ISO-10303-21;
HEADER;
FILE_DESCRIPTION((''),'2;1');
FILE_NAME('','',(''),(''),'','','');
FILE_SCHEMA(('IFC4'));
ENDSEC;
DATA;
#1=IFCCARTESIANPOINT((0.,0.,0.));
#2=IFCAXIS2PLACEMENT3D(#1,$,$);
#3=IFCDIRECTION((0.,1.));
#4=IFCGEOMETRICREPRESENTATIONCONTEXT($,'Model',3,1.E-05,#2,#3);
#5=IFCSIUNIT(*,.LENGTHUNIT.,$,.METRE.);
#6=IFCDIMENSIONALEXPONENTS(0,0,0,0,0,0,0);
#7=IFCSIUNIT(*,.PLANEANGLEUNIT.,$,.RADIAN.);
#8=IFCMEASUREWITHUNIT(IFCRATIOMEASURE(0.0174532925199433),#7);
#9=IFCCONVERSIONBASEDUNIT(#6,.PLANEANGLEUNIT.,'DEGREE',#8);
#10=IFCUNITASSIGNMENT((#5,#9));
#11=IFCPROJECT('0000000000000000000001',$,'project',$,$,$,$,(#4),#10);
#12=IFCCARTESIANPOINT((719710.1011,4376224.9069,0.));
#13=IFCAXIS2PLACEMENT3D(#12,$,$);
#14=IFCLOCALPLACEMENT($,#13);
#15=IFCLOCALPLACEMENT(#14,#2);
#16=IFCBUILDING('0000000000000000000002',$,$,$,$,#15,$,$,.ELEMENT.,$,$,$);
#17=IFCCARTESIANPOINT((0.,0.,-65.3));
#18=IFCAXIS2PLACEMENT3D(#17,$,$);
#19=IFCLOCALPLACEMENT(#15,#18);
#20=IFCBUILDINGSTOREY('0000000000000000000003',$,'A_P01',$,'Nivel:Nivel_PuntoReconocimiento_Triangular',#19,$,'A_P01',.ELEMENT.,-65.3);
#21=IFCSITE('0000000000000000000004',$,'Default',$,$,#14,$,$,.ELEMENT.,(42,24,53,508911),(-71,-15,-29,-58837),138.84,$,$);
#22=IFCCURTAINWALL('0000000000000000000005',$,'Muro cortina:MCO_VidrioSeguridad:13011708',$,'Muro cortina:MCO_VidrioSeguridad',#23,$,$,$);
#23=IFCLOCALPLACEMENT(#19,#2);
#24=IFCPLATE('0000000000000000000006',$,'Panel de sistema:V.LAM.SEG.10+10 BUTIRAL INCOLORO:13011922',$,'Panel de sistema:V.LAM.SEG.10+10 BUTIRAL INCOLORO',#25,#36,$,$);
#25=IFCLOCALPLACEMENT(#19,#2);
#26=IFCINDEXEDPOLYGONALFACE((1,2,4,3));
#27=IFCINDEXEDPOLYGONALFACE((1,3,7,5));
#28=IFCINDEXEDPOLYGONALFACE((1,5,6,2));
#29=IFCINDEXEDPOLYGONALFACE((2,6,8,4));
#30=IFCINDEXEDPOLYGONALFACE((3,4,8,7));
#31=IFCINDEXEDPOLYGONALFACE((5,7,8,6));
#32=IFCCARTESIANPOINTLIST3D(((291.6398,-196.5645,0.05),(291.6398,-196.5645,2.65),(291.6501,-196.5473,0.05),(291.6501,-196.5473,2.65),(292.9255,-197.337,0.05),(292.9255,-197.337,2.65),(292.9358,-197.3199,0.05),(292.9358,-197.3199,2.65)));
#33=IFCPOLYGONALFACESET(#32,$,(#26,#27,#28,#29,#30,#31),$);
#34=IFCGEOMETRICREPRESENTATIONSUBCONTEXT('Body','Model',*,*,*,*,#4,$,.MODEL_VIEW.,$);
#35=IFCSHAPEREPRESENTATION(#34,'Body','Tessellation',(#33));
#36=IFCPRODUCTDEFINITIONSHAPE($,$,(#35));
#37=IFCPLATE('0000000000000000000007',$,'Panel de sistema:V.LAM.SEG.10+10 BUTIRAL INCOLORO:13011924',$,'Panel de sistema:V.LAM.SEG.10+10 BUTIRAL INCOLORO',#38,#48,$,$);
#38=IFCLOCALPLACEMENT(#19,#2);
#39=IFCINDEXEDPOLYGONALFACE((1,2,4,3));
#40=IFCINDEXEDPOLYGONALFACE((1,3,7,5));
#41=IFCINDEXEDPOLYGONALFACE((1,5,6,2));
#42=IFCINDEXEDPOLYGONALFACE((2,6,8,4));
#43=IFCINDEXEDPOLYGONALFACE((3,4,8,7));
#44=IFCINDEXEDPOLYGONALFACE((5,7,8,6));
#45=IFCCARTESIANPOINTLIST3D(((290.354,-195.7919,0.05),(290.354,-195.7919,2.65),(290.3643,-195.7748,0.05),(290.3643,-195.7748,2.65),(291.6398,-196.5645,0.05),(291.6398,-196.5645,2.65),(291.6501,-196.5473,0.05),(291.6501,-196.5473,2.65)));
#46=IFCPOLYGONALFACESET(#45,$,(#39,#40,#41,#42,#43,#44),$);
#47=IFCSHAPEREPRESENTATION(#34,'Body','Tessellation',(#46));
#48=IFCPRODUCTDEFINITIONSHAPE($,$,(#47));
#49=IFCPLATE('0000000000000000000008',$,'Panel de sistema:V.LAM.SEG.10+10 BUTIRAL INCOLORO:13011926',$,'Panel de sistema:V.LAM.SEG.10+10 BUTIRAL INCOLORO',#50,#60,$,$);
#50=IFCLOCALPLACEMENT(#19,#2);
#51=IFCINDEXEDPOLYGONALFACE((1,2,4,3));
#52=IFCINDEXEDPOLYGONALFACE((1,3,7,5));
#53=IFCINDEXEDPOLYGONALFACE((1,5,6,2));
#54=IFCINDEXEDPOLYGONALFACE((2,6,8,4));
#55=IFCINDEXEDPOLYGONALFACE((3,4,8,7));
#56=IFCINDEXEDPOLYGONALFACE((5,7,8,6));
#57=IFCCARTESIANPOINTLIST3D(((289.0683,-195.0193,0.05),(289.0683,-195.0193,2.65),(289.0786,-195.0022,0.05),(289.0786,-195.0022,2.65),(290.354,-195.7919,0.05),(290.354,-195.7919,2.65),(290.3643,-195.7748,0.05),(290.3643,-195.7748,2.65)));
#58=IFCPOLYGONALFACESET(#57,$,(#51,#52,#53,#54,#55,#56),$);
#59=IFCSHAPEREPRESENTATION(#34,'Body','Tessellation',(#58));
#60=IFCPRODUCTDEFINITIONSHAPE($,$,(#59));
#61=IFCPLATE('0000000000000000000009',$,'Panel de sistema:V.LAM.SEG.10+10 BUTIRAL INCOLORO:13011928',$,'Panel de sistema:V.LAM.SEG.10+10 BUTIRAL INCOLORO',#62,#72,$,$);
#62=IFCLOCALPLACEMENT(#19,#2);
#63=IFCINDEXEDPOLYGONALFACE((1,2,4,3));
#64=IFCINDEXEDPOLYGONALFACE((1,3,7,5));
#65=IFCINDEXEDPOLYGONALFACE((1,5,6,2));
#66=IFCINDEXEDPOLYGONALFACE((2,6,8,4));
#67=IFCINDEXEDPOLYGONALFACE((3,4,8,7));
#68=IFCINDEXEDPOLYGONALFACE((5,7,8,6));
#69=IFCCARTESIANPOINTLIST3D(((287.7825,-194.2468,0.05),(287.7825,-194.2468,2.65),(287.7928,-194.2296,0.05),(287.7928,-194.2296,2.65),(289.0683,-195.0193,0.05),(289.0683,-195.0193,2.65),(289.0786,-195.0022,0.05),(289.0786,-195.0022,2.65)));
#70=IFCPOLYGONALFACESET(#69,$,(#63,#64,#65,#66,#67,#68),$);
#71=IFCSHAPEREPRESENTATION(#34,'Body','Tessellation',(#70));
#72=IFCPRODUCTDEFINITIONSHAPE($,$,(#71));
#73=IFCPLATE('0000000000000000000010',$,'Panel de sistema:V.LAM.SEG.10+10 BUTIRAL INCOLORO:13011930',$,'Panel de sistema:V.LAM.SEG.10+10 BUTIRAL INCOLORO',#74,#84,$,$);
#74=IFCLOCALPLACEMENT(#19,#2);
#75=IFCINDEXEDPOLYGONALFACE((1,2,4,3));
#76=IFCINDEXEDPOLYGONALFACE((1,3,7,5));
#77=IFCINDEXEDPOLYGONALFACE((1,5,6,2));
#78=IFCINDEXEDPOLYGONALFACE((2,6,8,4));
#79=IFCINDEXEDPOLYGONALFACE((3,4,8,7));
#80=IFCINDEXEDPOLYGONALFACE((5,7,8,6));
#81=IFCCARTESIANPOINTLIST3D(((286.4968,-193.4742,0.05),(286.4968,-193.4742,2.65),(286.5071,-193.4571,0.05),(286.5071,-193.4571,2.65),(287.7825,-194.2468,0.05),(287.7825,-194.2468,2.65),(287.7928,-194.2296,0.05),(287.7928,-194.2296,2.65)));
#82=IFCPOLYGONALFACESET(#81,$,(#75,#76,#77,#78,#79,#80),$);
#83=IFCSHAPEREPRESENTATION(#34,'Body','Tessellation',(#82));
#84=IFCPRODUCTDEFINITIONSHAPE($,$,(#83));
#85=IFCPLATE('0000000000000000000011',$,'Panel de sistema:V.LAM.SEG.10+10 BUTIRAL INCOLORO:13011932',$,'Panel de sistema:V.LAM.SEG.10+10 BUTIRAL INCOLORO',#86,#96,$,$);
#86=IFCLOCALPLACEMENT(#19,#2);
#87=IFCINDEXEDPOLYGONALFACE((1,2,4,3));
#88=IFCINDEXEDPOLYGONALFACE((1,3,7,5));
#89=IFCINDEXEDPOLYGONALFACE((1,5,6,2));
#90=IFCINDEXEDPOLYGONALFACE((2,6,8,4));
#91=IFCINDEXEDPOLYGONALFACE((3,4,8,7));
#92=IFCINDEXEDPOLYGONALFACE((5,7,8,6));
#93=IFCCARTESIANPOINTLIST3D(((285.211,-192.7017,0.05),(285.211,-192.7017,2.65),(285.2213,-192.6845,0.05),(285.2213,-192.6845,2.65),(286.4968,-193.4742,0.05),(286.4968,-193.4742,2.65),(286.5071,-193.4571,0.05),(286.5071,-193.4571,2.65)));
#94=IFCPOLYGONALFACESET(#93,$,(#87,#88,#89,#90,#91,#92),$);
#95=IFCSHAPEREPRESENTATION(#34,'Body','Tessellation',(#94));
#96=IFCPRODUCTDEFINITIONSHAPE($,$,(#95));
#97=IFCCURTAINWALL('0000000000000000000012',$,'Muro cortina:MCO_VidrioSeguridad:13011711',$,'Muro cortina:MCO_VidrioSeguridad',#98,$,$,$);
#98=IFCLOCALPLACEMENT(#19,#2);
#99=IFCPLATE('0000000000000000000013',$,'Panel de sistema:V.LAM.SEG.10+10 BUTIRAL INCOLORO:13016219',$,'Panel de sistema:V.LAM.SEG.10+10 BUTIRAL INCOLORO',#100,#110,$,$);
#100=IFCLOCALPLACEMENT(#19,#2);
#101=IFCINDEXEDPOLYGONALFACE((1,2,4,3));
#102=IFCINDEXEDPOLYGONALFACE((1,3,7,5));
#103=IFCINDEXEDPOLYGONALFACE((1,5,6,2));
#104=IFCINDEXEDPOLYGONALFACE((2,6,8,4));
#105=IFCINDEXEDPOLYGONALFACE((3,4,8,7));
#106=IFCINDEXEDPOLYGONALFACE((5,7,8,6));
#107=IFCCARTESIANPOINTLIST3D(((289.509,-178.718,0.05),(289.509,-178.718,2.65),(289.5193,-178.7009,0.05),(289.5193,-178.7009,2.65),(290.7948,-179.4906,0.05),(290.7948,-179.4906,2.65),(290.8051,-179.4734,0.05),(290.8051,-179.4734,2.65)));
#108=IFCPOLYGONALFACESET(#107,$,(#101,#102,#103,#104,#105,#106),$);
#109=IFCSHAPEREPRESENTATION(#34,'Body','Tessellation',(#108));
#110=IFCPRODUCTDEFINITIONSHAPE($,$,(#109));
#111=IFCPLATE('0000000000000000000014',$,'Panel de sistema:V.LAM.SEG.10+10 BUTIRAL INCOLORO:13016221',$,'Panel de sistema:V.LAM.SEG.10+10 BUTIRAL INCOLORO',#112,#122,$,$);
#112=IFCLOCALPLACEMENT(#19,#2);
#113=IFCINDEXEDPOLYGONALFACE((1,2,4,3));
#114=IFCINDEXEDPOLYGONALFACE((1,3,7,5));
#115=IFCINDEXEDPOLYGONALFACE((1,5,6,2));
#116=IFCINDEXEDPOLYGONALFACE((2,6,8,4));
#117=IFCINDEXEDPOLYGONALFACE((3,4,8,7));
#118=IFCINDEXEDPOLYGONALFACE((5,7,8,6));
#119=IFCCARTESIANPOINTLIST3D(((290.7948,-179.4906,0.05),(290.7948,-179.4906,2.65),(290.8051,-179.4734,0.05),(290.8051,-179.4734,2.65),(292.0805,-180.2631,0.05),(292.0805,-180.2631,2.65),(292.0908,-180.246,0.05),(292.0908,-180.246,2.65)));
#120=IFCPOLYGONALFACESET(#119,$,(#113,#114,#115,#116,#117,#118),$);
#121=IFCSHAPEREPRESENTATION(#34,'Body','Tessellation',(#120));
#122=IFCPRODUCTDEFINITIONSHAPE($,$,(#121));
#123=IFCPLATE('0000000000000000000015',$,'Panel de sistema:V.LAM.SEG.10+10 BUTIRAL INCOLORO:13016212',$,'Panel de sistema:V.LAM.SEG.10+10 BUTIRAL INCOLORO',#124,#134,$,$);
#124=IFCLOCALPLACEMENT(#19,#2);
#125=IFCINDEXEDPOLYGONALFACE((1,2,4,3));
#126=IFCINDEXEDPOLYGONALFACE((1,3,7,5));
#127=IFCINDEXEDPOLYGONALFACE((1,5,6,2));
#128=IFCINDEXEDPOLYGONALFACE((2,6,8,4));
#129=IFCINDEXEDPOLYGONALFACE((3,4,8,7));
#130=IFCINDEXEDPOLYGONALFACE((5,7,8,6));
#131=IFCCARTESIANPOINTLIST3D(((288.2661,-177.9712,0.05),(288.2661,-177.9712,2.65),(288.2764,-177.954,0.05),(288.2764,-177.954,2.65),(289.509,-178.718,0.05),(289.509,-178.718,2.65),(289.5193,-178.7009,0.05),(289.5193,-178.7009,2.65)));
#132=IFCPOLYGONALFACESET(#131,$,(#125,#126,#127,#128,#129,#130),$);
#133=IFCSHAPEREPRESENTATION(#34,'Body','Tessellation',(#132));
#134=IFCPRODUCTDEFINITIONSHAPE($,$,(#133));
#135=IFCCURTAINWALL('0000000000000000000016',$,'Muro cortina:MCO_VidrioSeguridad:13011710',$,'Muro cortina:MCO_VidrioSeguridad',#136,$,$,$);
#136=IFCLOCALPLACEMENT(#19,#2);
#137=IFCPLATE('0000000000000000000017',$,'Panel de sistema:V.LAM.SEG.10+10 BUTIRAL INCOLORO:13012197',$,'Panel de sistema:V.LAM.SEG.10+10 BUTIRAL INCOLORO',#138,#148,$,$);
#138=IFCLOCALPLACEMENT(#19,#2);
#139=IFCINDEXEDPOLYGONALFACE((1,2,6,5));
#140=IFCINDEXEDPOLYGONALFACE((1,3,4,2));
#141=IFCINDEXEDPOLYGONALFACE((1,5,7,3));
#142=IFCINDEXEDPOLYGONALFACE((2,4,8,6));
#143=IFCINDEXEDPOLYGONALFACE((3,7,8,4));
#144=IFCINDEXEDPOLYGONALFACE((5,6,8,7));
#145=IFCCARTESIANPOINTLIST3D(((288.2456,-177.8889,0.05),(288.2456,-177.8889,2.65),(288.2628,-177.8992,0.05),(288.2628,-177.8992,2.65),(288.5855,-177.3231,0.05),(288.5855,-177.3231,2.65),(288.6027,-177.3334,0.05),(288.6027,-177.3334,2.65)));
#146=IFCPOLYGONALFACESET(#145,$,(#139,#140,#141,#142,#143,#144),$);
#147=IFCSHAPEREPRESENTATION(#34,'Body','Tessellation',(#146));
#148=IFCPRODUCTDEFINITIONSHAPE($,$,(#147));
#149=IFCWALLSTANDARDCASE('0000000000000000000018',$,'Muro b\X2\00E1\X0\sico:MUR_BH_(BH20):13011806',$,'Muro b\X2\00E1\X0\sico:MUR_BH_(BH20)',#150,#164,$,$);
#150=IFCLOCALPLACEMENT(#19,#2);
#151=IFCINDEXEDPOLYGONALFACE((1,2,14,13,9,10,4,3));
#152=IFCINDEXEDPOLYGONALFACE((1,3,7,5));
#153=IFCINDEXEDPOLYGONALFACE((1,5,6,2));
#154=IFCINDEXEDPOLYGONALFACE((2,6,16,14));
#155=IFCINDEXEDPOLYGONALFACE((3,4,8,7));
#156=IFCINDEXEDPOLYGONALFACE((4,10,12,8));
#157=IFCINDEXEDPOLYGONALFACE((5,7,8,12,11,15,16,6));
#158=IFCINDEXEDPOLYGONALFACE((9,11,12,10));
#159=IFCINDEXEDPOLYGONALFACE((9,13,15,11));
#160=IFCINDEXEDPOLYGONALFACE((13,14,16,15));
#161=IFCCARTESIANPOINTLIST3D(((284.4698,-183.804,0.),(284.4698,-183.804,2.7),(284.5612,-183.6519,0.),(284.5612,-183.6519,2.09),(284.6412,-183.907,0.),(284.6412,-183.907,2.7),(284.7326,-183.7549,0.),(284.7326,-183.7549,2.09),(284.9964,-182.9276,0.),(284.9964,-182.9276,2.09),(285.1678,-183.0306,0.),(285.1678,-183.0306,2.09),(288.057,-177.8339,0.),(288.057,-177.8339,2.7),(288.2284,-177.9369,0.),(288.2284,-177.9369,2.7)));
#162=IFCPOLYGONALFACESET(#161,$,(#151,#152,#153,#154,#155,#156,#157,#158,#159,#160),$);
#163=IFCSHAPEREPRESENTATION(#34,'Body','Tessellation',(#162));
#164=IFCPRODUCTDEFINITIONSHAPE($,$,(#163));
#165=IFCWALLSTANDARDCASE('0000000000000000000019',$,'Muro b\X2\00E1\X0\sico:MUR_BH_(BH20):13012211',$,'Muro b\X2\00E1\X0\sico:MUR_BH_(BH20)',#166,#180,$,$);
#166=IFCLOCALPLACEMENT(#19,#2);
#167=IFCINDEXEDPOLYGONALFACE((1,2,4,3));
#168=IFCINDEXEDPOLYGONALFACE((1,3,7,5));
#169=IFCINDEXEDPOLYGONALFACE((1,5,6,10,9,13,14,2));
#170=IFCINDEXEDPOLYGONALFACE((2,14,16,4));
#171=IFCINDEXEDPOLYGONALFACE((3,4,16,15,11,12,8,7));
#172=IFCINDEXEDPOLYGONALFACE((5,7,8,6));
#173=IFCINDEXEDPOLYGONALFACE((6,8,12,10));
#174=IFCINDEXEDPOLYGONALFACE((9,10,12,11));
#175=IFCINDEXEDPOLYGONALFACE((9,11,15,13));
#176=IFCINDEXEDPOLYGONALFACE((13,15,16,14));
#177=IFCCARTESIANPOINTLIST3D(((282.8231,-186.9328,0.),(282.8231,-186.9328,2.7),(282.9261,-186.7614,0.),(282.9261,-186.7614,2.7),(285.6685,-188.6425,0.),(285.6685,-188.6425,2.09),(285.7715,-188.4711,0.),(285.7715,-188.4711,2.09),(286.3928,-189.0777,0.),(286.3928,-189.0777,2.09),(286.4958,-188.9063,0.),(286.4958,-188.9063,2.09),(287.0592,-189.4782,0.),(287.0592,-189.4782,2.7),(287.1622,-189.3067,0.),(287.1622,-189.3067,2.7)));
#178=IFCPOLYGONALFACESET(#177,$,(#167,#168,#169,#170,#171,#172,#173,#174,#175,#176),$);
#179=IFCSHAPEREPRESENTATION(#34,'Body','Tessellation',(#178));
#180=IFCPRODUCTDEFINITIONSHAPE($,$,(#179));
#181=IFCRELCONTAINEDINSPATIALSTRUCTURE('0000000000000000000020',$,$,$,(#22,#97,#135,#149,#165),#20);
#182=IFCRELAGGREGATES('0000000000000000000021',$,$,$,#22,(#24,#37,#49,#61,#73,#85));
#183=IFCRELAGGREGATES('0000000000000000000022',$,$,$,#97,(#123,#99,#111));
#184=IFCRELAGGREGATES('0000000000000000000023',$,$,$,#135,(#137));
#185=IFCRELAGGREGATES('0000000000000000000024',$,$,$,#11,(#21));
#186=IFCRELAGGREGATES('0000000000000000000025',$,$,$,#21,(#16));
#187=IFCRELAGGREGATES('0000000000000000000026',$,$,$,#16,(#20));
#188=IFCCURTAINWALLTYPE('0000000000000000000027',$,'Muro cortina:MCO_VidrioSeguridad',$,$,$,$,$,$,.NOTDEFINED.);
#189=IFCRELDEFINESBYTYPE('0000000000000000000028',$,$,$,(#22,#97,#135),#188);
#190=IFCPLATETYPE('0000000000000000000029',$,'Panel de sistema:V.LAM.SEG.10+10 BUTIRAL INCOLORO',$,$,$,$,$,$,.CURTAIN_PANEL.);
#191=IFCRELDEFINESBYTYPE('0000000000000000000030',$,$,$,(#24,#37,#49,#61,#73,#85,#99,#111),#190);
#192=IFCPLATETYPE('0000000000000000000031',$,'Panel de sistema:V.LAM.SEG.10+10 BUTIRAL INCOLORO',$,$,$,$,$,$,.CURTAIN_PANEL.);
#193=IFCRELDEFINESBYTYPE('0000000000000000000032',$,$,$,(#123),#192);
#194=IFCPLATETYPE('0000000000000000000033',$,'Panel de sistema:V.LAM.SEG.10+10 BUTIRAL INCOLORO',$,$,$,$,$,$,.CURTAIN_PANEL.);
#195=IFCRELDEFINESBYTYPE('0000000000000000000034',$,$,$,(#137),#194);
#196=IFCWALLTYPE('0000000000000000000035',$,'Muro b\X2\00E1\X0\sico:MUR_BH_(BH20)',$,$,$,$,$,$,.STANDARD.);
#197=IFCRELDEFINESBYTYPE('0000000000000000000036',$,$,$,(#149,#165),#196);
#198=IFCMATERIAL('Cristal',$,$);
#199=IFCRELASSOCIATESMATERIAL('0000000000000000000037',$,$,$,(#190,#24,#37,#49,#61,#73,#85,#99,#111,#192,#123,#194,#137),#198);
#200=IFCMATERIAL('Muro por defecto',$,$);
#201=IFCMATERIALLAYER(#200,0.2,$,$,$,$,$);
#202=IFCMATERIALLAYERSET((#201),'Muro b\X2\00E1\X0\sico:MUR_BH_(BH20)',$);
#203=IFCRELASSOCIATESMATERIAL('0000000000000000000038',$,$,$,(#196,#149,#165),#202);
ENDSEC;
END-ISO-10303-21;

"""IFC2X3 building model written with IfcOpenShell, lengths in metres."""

from ifc_helpers import new_model, entity, si_unit, converted_unit, direction, frame, frame_2d, origin, origin_2d_with_axis, place, context, subcontext, project, spatial, rectangle, extrude, source, transform, mapped, material, layer, layer_set, layer_usage, type_object, type_shapes, element, aggregate, save


model = new_model("IFC2X3")

# Units and contexts
model_context = context("Model", 3, precision=1e-05, world=origin(), true_north=direction((0.0, 1.0)))
body_context = subcontext(model_context, "Body", "Model", "MODEL_VIEW")
ifc_project = project(units=[si_unit("LENGTHUNIT", "METRE"), converted_unit("PLANEANGLEUNIT", "DEGREE", entity("IfcRatioMeasure", 0.0174532925199433), si_unit("PLANEANGLEUNIT", "RADIAN"), dimensions=[0, 0, 0, 0, 0, 0, 0])], contexts=[model_context])

# Site, building, storey
site_placement = place(None, frame((719710.1011, 4376224.9069, 0.0)))
site = spatial("IfcSite", under=ifc_project, at=site_placement, Name="Default", CompositionType="ELEMENT", RefLatitude=(42, 24, 53, 508911), RefLongitude=(-71, -15, -29, -58837), RefElevation=138.84)
building_placement = place(site_placement, origin())
building = spatial("IfcBuilding", under=site, at=building_placement, CompositionType="ELEMENT")
storey_placement = place(building_placement, frame((0.0, 0.0, -65.3)))
storey = spatial("IfcBuildingStorey", under=building, at=storey_placement, Name="A_P01", ObjectType="Nivel:Nivel_PuntoReconocimiento_Triangular", LongName="A_P01", CompositionType="ELEMENT", Elevation=-65.3)

# Curtain walls, plates
curtain_wall_type = type_object("IfcCurtainWallType", Name="Muro cortina:MCO_VidrioSeguridad", PredefinedType="NOTDEFINED")
curtain_wall_1_placement = place(storey_placement, frame((0.0, 0.0, 65.3)))
curtain_wall_1 = element("IfcCurtainWall", 1, at=curtain_wall_1_placement, inside=storey, type_object=curtain_wall_type, Name="Muro cortina:MCO_VidrioSeguridad:13011708", ObjectType="Muro cortina:MCO_VidrioSeguridad")
ifc_material_1 = material(Name="Cristal")
plate_type_1 = type_object("IfcPlateType", Name="Panel de sistema:V.LAM.SEG.10+10 BUTIRAL INCOLORO", PredefinedType="CURTAIN_PANEL", material=ifc_material_1)
shared_shape_1 = source(origin(), body_context, "Body", "SweptSolid", [
    extrude(rectangle(XDim=0.02, YDim=1.5, at=origin_2d_with_axis()), frame((0.0, 0.0, 0.0), z_axis=(0.0, 0.0, 1.0), x_axis=(0.0, 1.0, 0.0)), (0.0, 0.0, 1.0), 2.6),
])
type_shapes(plate_type_1, [shared_shape_1])
plate_1_placement = place(curtain_wall_1_placement, frame((292.2878, -196.9422, -65.25), z_axis=(0.0, 0.0, 1.0), x_axis=(-0.857167, 0.515038, 0.0)))
plate_1 = element("IfcPlate", 2, at=plate_1_placement, type_object=plate_type_1, material=ifc_material_1, Name="Panel de sistema:V.LAM.SEG.10+10 BUTIRAL INCOLORO:13011922", ObjectType="Panel de sistema:V.LAM.SEG.10+10 BUTIRAL INCOLORO", context=body_context, shape_type="MappedRepresentation", body=[
    mapped(shared_shape_1, transform((0.0, 0.0, 0.0), scale=1.0)),
])
plate_2_placement = place(curtain_wall_1_placement, frame((291.002, -196.1696, -65.25), z_axis=(0.0, 0.0, 1.0), x_axis=(-0.857167, 0.515038, 0.0)))
plate_2 = element("IfcPlate", 3, at=plate_2_placement, type_object=plate_type_1, material=ifc_material_1, Name="Panel de sistema:V.LAM.SEG.10+10 BUTIRAL INCOLORO:13011924", ObjectType="Panel de sistema:V.LAM.SEG.10+10 BUTIRAL INCOLORO", context=body_context, shape_type="MappedRepresentation", body=[
    mapped(shared_shape_1, transform((0.0, 0.0, 0.0), scale=1.0)),
])
plate_3_placement = place(curtain_wall_1_placement, frame((289.7163, -195.3971, -65.25), z_axis=(0.0, 0.0, 1.0), x_axis=(-0.857167, 0.515038, 0.0)))
plate_3 = element("IfcPlate", 4, at=plate_3_placement, type_object=plate_type_1, material=ifc_material_1, Name="Panel de sistema:V.LAM.SEG.10+10 BUTIRAL INCOLORO:13011926", ObjectType="Panel de sistema:V.LAM.SEG.10+10 BUTIRAL INCOLORO", context=body_context, shape_type="MappedRepresentation", body=[
    mapped(shared_shape_1, transform((0.0, 0.0, 0.0), scale=1.0)),
])
plate_4_placement = place(curtain_wall_1_placement, frame((288.4305, -194.6245, -65.25), z_axis=(0.0, 0.0, 1.0), x_axis=(-0.857167, 0.515038, 0.0)))
plate_4 = element("IfcPlate", 5, at=plate_4_placement, type_object=plate_type_1, material=ifc_material_1, Name="Panel de sistema:V.LAM.SEG.10+10 BUTIRAL INCOLORO:13011928", ObjectType="Panel de sistema:V.LAM.SEG.10+10 BUTIRAL INCOLORO", context=body_context, shape_type="MappedRepresentation", body=[
    mapped(shared_shape_1, transform((0.0, 0.0, 0.0), scale=1.0)),
])
plate_5_placement = place(curtain_wall_1_placement, frame((287.1448, -193.8519, -65.25), z_axis=(0.0, 0.0, 1.0), x_axis=(-0.857167, 0.515038, 0.0)))
plate_5 = element("IfcPlate", 6, at=plate_5_placement, type_object=plate_type_1, material=ifc_material_1, Name="Panel de sistema:V.LAM.SEG.10+10 BUTIRAL INCOLORO:13011930", ObjectType="Panel de sistema:V.LAM.SEG.10+10 BUTIRAL INCOLORO", context=body_context, shape_type="MappedRepresentation", body=[
    mapped(shared_shape_1, transform((0.0, 0.0, 0.0), scale=1.0)),
])
plate_6_placement = place(curtain_wall_1_placement, frame((285.859, -193.0794, -65.25), z_axis=(0.0, 0.0, 1.0), x_axis=(-0.857167, 0.515038, 0.0)))
plate_6 = element("IfcPlate", 7, at=plate_6_placement, type_object=plate_type_1, material=ifc_material_1, Name="Panel de sistema:V.LAM.SEG.10+10 BUTIRAL INCOLORO:13011932", ObjectType="Panel de sistema:V.LAM.SEG.10+10 BUTIRAL INCOLORO", context=body_context, shape_type="MappedRepresentation", body=[
    mapped(shared_shape_1, transform((0.0, 0.0, 0.0), scale=1.0)),
])
aggregate(curtain_wall_1, [plate_1, plate_2, plate_3, plate_4, plate_5, plate_6])
curtain_wall_2_placement = place(storey_placement, frame((0.0, 0.0, 65.3)))
curtain_wall_2 = element("IfcCurtainWall", 8, at=curtain_wall_2_placement, inside=storey, type_object=curtain_wall_type, Name="Muro cortina:MCO_VidrioSeguridad:13011711", ObjectType="Muro cortina:MCO_VidrioSeguridad")
plate_7_placement = place(curtain_wall_2_placement, frame((290.1571, -179.0957, -65.25), z_axis=(0.0, 0.0, 1.0), x_axis=(0.857167, -0.515038, 0.0)))
plate_7 = element("IfcPlate", 9, at=plate_7_placement, type_object=plate_type_1, material=ifc_material_1, Name="Panel de sistema:V.LAM.SEG.10+10 BUTIRAL INCOLORO:13016219", ObjectType="Panel de sistema:V.LAM.SEG.10+10 BUTIRAL INCOLORO", context=body_context, shape_type="MappedRepresentation", body=[
    mapped(shared_shape_1, transform((0.0, 0.0, 0.0), scale=1.0)),
])
plate_8_placement = place(curtain_wall_2_placement, frame((291.4428, -179.8683, -65.25), z_axis=(0.0, 0.0, 1.0), x_axis=(0.857167, -0.515038, 0.0)))
plate_8 = element("IfcPlate", 10, at=plate_8_placement, type_object=plate_type_1, material=ifc_material_1, Name="Panel de sistema:V.LAM.SEG.10+10 BUTIRAL INCOLORO:13016221", ObjectType="Panel de sistema:V.LAM.SEG.10+10 BUTIRAL INCOLORO", context=body_context, shape_type="MappedRepresentation", body=[
    mapped(shared_shape_1, transform((0.0, 0.0, 0.0), scale=1.0)),
])
plate_type_2 = type_object("IfcPlateType", Name="Panel de sistema:V.LAM.SEG.10+10 BUTIRAL INCOLORO", PredefinedType="CURTAIN_PANEL", material=ifc_material_1)
shared_shape_2 = source(origin(), body_context, "Body", "SweptSolid", [
    extrude(rectangle(XDim=0.02, YDim=1.45, at=origin_2d_with_axis()), frame((0.0, 0.0, 0.0), z_axis=(0.0, 0.0, 1.0), x_axis=(0.0, 1.0, 0.0)), (0.0, 0.0, 1.0), 2.6),
])
type_shapes(plate_type_2, [shared_shape_2])
plate_9_placement = place(curtain_wall_2_placement, frame((288.8927, -178.336, -65.25), z_axis=(0.0, 0.0, 1.0), x_axis=(0.857167, -0.515038, 0.0)))
plate_9 = element("IfcPlate", 11, at=plate_9_placement, type_object=plate_type_2, material=ifc_material_1, Name="Panel de sistema:V.LAM.SEG.10+10 BUTIRAL INCOLORO:13016212", ObjectType="Panel de sistema:V.LAM.SEG.10+10 BUTIRAL INCOLORO", context=body_context, shape_type="MappedRepresentation", body=[
    mapped(shared_shape_2, transform((0.0, 0.0, 0.0), scale=1.0)),
])
aggregate(curtain_wall_2, [plate_9, plate_7, plate_8])

# Curtain wall, plate
curtain_wall_3_placement = place(storey_placement, frame((0.0, 0.0, 65.3)))
curtain_wall_3 = element("IfcCurtainWall", 12, at=curtain_wall_3_placement, inside=storey, type_object=curtain_wall_type, Name="Muro cortina:MCO_VidrioSeguridad:13011710", ObjectType="Muro cortina:MCO_VidrioSeguridad")
plate_type_3 = type_object("IfcPlateType", Name="Panel de sistema:V.LAM.SEG.10+10 BUTIRAL INCOLORO", PredefinedType="CURTAIN_PANEL", material=ifc_material_1)
shared_shape_3 = source(origin(), body_context, "Body", "SweptSolid", [
    extrude(rectangle(XDim=0.02, YDim=0.66, at=origin_2d_with_axis()), frame((0.0, 0.0, 0.0), z_axis=(0.0, 0.0, 1.0), x_axis=(0.0, 1.0, 0.0)), (0.0, 0.0, 1.0), 2.6),
])
type_shapes(plate_type_3, [shared_shape_3])
plate_10_placement = place(curtain_wall_3_placement, frame((288.4241, -177.6111, -65.25), z_axis=(0.0, 0.0, 1.0), x_axis=(-0.515038, -0.857167, 0.0)))
plate_10 = element("IfcPlate", 13, at=plate_10_placement, type_object=plate_type_3, material=ifc_material_1, Name="Panel de sistema:V.LAM.SEG.10+10 BUTIRAL INCOLORO:13012197", ObjectType="Panel de sistema:V.LAM.SEG.10+10 BUTIRAL INCOLORO", context=body_context, shape_type="MappedRepresentation", body=[
    mapped(shared_shape_3, transform((0.0, 0.0, 0.0), scale=1.0)),
])
aggregate(curtain_wall_3, [plate_10])

# Walls, openings
ifc_material_2 = material(Name="Muro por defecto")
ifc_layer = layer(ifc_material_2, 0.2)
ifc_layer_set = layer_set([ifc_layer], Name="Muro básico:MUR_BH_(BH20)")
ifc_layer_usage_1 = layer_usage(ifc_layer_set, "AXIS2", "NEGATIVE", 0.1)
wall_type = type_object("IfcWallType", Name="Muro básico:MUR_BH_(BH20)", PredefinedType="STANDARD", material=ifc_layer_set)
wall_1_placement = place(storey_placement, frame((288.1427, -177.8854, 0.0), z_axis=(0.0, 0.0, 1.0), x_axis=(-0.515038, -0.857167, 0.0)))
wall_1 = element("IfcWallStandardCase", 14, at=wall_1_placement, inside=storey, type_object=wall_type, material=ifc_layer_usage_1, Name="Muro básico:MUR_BH_(BH20):13011806", ObjectType="Muro básico:MUR_BH_(BH20)", context=body_context, shape_type="SweptSolid", body=[
    extrude(rectangle(XDim=6.965, YDim=0.2, at=frame_2d((3.4825, 0.0), x_axis=(-1.0, 0.0))), origin(), (0.0, 0.0, 1.0), 2.7),
])
opening_1_placement = place(wall_1_placement, frame((-4.073, -338.6042, 0.0), z_axis=(0.0, 0.0, 1.0), x_axis=(-0.515038, 0.857167, 0.0)))
element("IfcOpeningElement", 15, at=opening_1_placement, cuts=wall_1, ObjectType="Opening", context=body_context, shape_type="SweptSolid", body=[
    extrude(rectangle(XDim=2.09, YDim=0.845, at=frame_2d((0.0, 0.0), x_axis=(1.0, 0.0))), frame((284.7788, -183.2897, 1.045), z_axis=(0.857167, -0.515038, 0.0), x_axis=(0.0, 0.0, -1.0)), (0.0, 0.0, 1.0), 0.2),
])
ifc_layer_usage_2 = layer_usage(ifc_layer_set, "AXIS2", "NEGATIVE", 0.1)
wall_2_placement = place(storey_placement, frame((287.1107, -189.3924, 0.0), z_axis=(0.0, 0.0, 1.0), x_axis=(-0.857167, 0.515038, 0.0)))
wall_2 = element("IfcWallStandardCase", 16, at=wall_2_placement, inside=storey, type_object=wall_type, material=ifc_layer_usage_2, Name="Muro básico:MUR_BH_(BH20):13012211", ObjectType="Muro básico:MUR_BH_(BH20)", context=body_context, shape_type="SweptSolid", body=[
    extrude(rectangle(XDim=4.942, YDim=0.2, at=frame_2d((2.471, 0.0), x_axis=(-1.0, 0.0))), origin(), (0.0, 0.0, 1.0), 2.7),
])
opening_2_placement = place(wall_2_placement, frame((343.6462, -14.468, 0.0), z_axis=(0.0, 0.0, 1.0), x_axis=(-0.857167, -0.515038, 0.0)))
element("IfcOpeningElement", 17, at=opening_2_placement, cuts=wall_2, ObjectType="Opening", context=body_context, shape_type="SweptSolid", body=[
    extrude(rectangle(XDim=2.09, YDim=0.845, at=frame_2d((0.0, 0.0), x_axis=(0.0, 1.0))), frame((286.1336, -188.6887, 1.045), z_axis=(-0.515038, -0.857167, 0.0), x_axis=(-0.857167, 0.515038, 0.0)), (0.0, 0.0, 1.0), 0.2),
])

save(model, "model.ifc")
